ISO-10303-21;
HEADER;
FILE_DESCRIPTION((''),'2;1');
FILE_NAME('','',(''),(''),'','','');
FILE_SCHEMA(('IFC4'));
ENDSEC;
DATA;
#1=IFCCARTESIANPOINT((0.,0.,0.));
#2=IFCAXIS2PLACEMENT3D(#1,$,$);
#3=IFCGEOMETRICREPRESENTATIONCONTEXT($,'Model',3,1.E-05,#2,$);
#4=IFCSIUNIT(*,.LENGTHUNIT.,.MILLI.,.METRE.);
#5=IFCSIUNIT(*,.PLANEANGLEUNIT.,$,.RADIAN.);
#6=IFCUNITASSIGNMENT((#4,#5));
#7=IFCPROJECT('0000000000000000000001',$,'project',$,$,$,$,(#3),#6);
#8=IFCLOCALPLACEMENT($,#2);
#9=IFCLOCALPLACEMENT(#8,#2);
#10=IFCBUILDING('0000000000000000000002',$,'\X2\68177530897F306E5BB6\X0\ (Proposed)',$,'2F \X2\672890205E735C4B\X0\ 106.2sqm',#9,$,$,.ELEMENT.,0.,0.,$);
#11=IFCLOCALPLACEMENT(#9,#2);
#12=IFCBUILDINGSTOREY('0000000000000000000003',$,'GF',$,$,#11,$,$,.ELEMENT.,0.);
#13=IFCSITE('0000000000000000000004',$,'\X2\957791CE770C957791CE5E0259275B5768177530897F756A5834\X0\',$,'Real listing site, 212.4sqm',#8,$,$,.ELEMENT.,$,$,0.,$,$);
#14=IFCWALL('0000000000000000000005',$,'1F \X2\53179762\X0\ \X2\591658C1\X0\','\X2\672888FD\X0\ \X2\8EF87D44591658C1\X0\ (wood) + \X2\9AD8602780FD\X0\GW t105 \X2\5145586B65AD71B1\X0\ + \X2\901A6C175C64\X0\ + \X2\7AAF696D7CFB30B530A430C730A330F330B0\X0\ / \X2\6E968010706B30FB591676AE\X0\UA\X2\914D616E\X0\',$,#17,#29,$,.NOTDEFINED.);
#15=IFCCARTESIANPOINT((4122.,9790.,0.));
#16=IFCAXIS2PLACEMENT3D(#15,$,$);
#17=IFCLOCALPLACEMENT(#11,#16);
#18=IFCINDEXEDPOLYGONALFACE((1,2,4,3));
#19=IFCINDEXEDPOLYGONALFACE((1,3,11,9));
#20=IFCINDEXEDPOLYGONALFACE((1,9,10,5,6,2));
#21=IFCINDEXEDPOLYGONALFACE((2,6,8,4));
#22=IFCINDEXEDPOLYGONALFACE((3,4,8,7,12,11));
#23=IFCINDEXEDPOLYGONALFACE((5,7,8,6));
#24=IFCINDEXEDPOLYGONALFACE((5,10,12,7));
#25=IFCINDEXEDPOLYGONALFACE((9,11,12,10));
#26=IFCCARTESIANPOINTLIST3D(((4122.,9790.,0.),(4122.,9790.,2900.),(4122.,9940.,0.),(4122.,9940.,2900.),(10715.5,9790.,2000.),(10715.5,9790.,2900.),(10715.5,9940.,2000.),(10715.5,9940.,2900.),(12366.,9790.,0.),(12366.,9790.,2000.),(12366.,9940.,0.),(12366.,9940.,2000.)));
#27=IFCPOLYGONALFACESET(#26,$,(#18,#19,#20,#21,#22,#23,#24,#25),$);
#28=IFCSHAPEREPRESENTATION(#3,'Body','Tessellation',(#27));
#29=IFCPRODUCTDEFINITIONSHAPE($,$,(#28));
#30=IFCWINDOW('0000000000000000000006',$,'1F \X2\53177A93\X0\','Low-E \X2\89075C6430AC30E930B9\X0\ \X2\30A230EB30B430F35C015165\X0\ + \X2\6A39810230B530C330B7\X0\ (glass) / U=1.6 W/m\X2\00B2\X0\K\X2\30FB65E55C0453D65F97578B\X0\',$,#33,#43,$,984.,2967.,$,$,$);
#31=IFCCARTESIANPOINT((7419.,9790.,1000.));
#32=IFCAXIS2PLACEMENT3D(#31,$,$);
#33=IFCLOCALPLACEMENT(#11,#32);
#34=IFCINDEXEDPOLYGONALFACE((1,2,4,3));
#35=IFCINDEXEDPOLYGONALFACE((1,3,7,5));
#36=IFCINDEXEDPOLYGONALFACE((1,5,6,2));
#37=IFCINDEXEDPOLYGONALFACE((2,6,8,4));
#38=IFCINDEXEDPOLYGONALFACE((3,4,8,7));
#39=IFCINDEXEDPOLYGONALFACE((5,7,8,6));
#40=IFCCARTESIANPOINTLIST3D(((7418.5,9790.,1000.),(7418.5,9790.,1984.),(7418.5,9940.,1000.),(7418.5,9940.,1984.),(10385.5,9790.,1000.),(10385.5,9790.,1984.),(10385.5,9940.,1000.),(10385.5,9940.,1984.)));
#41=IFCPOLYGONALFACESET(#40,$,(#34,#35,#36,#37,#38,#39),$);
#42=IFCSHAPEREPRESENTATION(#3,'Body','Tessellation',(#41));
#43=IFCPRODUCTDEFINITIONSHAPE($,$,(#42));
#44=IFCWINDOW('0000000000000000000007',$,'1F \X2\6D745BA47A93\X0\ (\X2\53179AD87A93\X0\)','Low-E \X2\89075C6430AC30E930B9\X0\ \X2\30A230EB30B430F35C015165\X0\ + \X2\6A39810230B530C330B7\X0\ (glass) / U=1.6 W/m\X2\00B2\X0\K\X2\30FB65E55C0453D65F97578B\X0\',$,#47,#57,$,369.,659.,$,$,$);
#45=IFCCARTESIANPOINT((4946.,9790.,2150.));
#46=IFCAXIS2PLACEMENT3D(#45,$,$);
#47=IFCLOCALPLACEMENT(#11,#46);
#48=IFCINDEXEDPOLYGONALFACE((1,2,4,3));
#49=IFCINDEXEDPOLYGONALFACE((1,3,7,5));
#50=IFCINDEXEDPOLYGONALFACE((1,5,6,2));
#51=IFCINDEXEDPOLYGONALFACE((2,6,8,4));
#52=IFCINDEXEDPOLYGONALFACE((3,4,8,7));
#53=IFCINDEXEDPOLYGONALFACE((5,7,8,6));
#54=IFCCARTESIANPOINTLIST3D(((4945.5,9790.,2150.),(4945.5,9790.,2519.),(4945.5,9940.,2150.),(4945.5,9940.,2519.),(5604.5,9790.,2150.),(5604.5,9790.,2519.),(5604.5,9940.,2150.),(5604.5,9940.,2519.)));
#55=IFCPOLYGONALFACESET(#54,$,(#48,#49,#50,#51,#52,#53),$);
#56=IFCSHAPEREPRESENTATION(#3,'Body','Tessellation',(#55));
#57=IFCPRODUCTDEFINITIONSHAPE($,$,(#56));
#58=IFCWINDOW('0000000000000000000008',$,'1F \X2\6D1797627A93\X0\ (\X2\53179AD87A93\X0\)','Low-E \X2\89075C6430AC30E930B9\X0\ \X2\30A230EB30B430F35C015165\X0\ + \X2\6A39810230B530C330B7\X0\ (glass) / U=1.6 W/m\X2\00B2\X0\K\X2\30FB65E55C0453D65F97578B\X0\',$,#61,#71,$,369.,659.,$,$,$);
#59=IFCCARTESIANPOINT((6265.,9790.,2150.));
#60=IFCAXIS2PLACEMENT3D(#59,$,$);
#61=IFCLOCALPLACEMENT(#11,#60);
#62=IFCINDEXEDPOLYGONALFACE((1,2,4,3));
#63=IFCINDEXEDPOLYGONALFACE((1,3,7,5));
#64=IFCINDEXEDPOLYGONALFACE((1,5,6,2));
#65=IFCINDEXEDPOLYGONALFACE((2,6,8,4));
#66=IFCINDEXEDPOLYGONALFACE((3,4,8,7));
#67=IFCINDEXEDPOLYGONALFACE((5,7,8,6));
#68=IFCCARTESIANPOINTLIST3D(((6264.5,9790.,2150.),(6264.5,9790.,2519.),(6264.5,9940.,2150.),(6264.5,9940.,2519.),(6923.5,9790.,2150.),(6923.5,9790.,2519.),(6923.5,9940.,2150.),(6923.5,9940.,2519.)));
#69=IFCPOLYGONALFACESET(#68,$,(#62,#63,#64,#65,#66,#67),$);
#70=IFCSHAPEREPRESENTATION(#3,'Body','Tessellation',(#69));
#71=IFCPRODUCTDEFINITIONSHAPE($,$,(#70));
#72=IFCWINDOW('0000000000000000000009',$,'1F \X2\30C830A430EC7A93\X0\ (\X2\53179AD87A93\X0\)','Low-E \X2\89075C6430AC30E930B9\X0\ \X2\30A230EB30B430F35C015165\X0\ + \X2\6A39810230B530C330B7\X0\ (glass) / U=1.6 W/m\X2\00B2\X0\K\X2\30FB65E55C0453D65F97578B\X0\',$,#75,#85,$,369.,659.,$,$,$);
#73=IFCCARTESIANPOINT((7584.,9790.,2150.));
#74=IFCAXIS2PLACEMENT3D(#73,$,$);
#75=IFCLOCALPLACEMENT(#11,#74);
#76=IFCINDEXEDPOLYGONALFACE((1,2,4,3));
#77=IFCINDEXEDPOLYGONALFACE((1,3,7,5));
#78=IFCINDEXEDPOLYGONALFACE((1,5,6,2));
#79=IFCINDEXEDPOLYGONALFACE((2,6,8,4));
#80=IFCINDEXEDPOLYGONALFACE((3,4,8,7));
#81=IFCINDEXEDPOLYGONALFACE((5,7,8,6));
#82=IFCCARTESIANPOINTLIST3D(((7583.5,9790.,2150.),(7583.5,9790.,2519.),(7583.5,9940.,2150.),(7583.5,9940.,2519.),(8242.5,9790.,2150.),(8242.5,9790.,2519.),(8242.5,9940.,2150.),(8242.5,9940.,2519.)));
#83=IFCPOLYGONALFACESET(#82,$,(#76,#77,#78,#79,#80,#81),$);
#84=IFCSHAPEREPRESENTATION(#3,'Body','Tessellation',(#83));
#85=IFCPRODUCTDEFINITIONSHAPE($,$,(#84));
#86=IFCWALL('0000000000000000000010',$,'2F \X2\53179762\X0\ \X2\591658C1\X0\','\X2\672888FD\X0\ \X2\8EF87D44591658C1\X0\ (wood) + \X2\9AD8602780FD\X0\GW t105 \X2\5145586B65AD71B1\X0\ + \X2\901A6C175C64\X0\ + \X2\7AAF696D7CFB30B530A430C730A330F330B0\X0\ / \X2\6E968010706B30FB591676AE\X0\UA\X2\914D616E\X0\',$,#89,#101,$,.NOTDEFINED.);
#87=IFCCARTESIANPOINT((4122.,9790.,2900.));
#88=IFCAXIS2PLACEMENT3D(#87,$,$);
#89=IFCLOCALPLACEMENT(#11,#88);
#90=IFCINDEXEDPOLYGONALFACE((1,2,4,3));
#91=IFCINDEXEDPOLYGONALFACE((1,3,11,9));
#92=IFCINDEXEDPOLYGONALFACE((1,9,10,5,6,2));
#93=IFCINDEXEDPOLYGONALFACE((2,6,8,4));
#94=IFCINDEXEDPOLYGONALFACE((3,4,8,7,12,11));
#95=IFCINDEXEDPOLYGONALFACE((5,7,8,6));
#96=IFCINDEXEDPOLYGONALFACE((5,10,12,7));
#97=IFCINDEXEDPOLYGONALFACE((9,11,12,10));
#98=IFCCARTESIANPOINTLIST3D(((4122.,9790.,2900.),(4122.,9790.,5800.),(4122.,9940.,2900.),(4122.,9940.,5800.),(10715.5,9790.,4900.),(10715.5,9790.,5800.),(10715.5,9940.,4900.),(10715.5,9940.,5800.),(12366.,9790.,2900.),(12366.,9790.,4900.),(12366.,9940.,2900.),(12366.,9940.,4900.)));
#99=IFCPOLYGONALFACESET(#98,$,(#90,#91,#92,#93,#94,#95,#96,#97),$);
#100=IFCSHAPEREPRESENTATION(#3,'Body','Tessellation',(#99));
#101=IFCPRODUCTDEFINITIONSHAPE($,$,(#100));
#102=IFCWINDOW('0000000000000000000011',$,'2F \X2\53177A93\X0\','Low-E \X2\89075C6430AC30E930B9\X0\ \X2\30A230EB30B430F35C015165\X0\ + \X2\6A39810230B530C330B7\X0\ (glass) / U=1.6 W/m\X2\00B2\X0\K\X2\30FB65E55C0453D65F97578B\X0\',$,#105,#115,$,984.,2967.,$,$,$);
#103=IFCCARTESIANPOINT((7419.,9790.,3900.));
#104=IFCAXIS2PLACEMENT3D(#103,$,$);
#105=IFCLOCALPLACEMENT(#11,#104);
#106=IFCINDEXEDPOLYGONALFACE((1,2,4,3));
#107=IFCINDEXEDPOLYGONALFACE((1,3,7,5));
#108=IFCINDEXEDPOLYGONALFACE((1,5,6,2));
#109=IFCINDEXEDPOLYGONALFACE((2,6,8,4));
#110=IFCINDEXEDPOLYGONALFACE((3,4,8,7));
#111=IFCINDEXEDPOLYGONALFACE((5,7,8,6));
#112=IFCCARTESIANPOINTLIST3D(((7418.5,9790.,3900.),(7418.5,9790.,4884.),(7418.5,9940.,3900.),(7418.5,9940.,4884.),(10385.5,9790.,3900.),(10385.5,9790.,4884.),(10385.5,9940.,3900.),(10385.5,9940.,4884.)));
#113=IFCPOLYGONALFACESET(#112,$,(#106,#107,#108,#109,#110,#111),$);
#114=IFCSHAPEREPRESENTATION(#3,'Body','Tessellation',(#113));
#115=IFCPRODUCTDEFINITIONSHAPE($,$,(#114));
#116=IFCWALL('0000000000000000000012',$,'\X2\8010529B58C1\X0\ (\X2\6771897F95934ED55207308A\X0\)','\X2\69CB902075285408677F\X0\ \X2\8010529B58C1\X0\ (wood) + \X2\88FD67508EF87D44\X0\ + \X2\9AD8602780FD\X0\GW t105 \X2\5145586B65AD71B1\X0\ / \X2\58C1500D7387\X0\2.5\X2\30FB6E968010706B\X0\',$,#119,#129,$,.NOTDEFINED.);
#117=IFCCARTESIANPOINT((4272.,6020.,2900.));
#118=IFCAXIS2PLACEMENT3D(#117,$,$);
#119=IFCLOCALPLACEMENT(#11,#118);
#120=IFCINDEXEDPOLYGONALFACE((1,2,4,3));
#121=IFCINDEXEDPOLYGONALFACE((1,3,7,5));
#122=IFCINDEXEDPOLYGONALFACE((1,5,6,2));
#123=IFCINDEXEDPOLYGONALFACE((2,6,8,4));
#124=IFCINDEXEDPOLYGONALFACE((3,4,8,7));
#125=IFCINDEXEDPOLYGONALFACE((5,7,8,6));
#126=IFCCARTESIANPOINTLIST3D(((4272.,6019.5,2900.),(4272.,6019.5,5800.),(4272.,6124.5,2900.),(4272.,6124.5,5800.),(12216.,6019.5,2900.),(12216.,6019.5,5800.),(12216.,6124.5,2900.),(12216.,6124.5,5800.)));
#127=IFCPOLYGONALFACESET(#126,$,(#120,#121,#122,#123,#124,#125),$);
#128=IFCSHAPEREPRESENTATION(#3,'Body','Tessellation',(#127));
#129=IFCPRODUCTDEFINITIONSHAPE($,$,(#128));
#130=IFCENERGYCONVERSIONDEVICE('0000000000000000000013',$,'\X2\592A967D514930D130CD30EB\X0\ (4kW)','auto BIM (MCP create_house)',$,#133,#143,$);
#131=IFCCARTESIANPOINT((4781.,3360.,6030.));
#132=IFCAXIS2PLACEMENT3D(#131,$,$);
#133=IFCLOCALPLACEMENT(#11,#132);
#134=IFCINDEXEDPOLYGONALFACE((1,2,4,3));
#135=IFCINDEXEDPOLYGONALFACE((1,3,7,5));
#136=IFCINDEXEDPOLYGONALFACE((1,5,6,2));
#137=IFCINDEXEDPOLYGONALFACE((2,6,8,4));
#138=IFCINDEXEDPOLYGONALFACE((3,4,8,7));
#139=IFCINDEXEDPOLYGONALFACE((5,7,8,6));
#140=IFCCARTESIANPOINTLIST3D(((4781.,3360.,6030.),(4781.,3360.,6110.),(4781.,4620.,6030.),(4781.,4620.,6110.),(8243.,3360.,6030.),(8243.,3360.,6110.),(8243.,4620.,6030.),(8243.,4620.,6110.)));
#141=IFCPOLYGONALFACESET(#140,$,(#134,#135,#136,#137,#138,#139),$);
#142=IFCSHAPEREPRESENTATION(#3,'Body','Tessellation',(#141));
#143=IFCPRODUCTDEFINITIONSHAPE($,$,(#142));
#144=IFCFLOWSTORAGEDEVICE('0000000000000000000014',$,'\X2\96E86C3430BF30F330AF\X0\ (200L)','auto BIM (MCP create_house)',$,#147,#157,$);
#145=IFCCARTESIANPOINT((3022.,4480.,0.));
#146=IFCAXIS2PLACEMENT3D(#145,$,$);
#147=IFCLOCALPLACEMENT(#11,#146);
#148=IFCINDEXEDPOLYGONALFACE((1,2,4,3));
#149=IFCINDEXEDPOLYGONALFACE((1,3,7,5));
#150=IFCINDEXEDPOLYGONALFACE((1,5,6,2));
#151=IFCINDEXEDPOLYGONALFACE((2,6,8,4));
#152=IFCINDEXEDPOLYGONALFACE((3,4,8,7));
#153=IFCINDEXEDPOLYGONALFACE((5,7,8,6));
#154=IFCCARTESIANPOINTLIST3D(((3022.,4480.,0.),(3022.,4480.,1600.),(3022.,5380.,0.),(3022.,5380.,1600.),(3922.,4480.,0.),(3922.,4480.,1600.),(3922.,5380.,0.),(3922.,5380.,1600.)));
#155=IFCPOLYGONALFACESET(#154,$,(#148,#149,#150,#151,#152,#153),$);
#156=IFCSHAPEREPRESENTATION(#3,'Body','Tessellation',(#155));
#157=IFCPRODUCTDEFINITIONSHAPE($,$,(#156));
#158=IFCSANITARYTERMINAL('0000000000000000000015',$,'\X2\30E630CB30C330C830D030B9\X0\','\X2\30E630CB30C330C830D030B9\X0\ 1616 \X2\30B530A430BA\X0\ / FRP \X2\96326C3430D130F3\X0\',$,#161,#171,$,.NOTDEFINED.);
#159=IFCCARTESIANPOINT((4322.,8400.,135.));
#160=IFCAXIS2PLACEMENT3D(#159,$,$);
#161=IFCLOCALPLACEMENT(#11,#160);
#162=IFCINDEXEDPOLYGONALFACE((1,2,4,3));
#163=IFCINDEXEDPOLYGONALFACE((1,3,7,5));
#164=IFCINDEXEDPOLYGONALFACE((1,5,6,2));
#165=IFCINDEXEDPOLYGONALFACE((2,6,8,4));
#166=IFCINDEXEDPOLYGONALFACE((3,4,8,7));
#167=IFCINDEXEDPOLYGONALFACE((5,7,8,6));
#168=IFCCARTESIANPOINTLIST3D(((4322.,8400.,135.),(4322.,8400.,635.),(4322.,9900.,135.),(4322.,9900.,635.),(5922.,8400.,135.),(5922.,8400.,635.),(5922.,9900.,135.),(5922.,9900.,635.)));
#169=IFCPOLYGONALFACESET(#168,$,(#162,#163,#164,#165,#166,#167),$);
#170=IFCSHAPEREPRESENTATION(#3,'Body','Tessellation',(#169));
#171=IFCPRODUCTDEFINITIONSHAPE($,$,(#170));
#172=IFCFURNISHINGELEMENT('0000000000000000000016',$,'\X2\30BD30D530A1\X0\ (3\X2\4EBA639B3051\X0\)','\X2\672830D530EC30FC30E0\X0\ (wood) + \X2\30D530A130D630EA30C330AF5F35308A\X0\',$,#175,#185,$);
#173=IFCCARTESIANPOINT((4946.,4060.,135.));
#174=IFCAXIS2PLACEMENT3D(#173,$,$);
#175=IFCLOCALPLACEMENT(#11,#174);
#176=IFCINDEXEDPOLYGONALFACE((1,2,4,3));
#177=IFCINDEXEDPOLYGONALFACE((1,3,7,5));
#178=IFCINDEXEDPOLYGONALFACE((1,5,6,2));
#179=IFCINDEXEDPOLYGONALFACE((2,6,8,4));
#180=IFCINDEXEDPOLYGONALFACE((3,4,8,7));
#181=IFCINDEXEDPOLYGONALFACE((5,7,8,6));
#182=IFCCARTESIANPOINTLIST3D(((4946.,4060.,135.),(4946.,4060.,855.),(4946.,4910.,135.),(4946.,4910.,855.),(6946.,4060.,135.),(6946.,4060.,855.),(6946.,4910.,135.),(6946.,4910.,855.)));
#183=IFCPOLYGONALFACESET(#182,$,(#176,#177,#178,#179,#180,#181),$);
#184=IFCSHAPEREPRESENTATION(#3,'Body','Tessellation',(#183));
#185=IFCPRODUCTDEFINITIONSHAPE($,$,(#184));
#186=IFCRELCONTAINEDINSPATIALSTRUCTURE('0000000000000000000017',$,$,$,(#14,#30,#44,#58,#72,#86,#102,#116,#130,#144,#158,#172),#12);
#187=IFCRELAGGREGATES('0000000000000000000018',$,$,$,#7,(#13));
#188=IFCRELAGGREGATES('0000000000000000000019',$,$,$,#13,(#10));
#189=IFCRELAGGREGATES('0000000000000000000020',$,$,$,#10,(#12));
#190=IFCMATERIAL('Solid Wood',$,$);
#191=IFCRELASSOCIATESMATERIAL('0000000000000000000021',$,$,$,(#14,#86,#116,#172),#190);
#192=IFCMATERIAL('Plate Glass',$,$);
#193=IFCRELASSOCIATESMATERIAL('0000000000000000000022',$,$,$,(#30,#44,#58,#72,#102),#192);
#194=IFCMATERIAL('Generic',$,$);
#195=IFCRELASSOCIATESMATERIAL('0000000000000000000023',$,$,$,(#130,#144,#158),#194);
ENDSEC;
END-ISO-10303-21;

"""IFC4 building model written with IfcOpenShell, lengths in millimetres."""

from ifc_helpers import new_model, si_unit, frame, frame_2d, origin, place, context, project, spatial, rectangle, extrude, material, element, fill, save


model = new_model("IFC4")

# Units and contexts
model_context = context("Model", 3, precision=1e-05, world=origin())
ifc_project = project(units=[si_unit("LENGTHUNIT", "METRE", prefix="MILLI"), si_unit("PLANEANGLEUNIT", "RADIAN")], contexts=[model_context])

# Site, building, storey
site_placement = place(None, origin())
site = spatial("IfcSite", under=ifc_project, at=site_placement, Name="長野県長野市大字栗田西番場", ObjectType="Real listing site, 212.4sqm", CompositionType="ELEMENT", RefElevation=0.0)
building_placement = place(site_placement, origin())
building = spatial("IfcBuilding", under=site, at=building_placement, Name="栗田西の家 (Proposed)", ObjectType="2F 木造平屋 106.2sqm", CompositionType="ELEMENT", ElevationOfRefHeight=0.0, ElevationOfTerrain=0.0)
storey_placement = place(building_placement, origin())
storey = spatial("IfcBuildingStorey", under=building, at=storey_placement, Name="GF", CompositionType="ELEMENT", Elevation=0.0)

# Wall, openings, windows
ifc_material_1 = material(Name="Solid Wood")
wall_1_placement = place(storey_placement, frame((4122.0, 9790.0, 0.0)))
wall_1 = element("IfcWall", 1, at=wall_1_placement, inside=storey, material=ifc_material_1, Name="1F 北面 外壁", Description="木製 軸組外壁 (wood) + 高性能GW t105 充填断熱 + 通気層 + 窯業系サイディング / 準耐火・外皮UA配慮", PredefinedType="NOTDEFINED", context=model_context, shape_type="SweptSolid", body=[
    extrude(rectangle(XDim=8244.0, YDim=150.0, at=frame_2d((4122.0, 75.0))), frame((4122.0, 9790.0, 0.0)), (0.0, 0.0, 1.0), 2900.0),
])
opening_1_placement = place(storey_placement, frame((7419.0, 9790.0, 1000.0)))
opening_1 = element("IfcOpeningElement", 2, at=opening_1_placement, cuts=wall_1, PredefinedType="NOTDEFINED", context=model_context, shape_type="SweptSolid", body=[
    extrude(rectangle(XDim=2967.0, YDim=150.0, at=frame_2d((1483.0, 75.0))), frame((7419.0, 9790.0, 1000.0)), (0.0, 0.0, 1.0), 984.0),
])
opening_2_placement = place(storey_placement, frame((4946.0, 9790.0, 2150.0)))
opening_2 = element("IfcOpeningElement", 3, at=opening_2_placement, cuts=wall_1, PredefinedType="NOTDEFINED", context=model_context, shape_type="SweptSolid", body=[
    extrude(rectangle(XDim=659.0, YDim=150.0, at=frame_2d((329.0, 75.0))), frame((4946.0, 9790.0, 2150.0)), (0.0, 0.0, 1.0), 369.0),
])
opening_3_placement = place(storey_placement, frame((6265.0, 9790.0, 2150.0)))
opening_3 = element("IfcOpeningElement", 4, at=opening_3_placement, cuts=wall_1, PredefinedType="NOTDEFINED", context=model_context, shape_type="SweptSolid", body=[
    extrude(rectangle(XDim=659.0, YDim=150.0, at=frame_2d((329.0, 75.0))), frame((6265.0, 9790.0, 2150.0)), (0.0, 0.0, 1.0), 369.0),
])
opening_4_placement = place(storey_placement, frame((7584.0, 9790.0, 2150.0)))
opening_4 = element("IfcOpeningElement", 5, at=opening_4_placement, cuts=wall_1, PredefinedType="NOTDEFINED", context=model_context, shape_type="SweptSolid", body=[
    extrude(rectangle(XDim=659.0, YDim=150.0, at=frame_2d((329.0, 75.0))), frame((7584.0, 9790.0, 2150.0)), (0.0, 0.0, 1.0), 369.0),
])
ifc_material_2 = material(Name="Plate Glass")
window_1_placement = place(storey_placement, frame((7419.0, 9790.0, 1000.0)))
window_1 = element("IfcWindow", 6, at=window_1_placement, inside=storey, material=ifc_material_2, Name="1F 北窓", Description="Low-E 複層ガラス アルゴン封入 + 樹脂サッシ (glass) / U=1.6 W/m²K・日射取得型", OverallHeight=984.0, OverallWidth=2967.0, context=model_context, shape_type="SweptSolid", body=[
    extrude(rectangle(XDim=2967.0, YDim=150.0, at=frame_2d((1483.0, 75.0))), frame((7419.0, 9790.0, 1000.0)), (0.0, 0.0, 1.0), 984.0),
])
fill(opening_1, window_1)
window_2_placement = place(storey_placement, frame((4946.0, 9790.0, 2150.0)))
window_2 = element("IfcWindow", 7, at=window_2_placement, inside=storey, material=ifc_material_2, Name="1F 浴室窓 (北高窓)", Description="Low-E 複層ガラス アルゴン封入 + 樹脂サッシ (glass) / U=1.6 W/m²K・日射取得型", OverallHeight=369.0, OverallWidth=659.0, context=model_context, shape_type="SweptSolid", body=[
    extrude(rectangle(XDim=659.0, YDim=150.0, at=frame_2d((329.0, 75.0))), frame((4946.0, 9790.0, 2150.0)), (0.0, 0.0, 1.0), 369.0),
])
fill(opening_2, window_2)
window_3_placement = place(storey_placement, frame((6265.0, 9790.0, 2150.0)))
window_3 = element("IfcWindow", 8, at=window_3_placement, inside=storey, material=ifc_material_2, Name="1F 洗面窓 (北高窓)", Description="Low-E 複層ガラス アルゴン封入 + 樹脂サッシ (glass) / U=1.6 W/m²K・日射取得型", OverallHeight=369.0, OverallWidth=659.0, context=model_context, shape_type="SweptSolid", body=[
    extrude(rectangle(XDim=659.0, YDim=150.0, at=frame_2d((329.0, 75.0))), frame((6265.0, 9790.0, 2150.0)), (0.0, 0.0, 1.0), 369.0),
])
fill(opening_3, window_3)
window_4_placement = place(storey_placement, frame((7584.0, 9790.0, 2150.0)))
window_4 = element("IfcWindow", 9, at=window_4_placement, inside=storey, material=ifc_material_2, Name="1F トイレ窓 (北高窓)", Description="Low-E 複層ガラス アルゴン封入 + 樹脂サッシ (glass) / U=1.6 W/m²K・日射取得型", OverallHeight=369.0, OverallWidth=659.0, context=model_context, shape_type="SweptSolid", body=[
    extrude(rectangle(XDim=659.0, YDim=150.0, at=frame_2d((329.0, 75.0))), frame((7584.0, 9790.0, 2150.0)), (0.0, 0.0, 1.0), 369.0),
])
fill(opening_4, window_4)

# Wall, opening, window
wall_2_placement = place(storey_placement, frame((4122.0, 9790.0, 2900.0)))
wall_2 = element("IfcWall", 10, at=wall_2_placement, inside=storey, material=ifc_material_1, Name="2F 北面 外壁", Description="木製 軸組外壁 (wood) + 高性能GW t105 充填断熱 + 通気層 + 窯業系サイディング / 準耐火・外皮UA配慮", PredefinedType="NOTDEFINED", context=model_context, shape_type="SweptSolid", body=[
    extrude(rectangle(XDim=8244.0, YDim=150.0, at=frame_2d((4122.0, 75.0))), frame((4122.0, 9790.0, 2900.0)), (0.0, 0.0, 1.0), 2900.0),
])
opening_5_placement = place(storey_placement, frame((7419.0, 9790.0, 3900.0)))
opening_5 = element("IfcOpeningElement", 11, at=opening_5_placement, cuts=wall_2, PredefinedType="NOTDEFINED", context=model_context, shape_type="SweptSolid", body=[
    extrude(rectangle(XDim=2967.0, YDim=150.0, at=frame_2d((1483.0, 75.0))), frame((7419.0, 9790.0, 3900.0)), (0.0, 0.0, 1.0), 984.0),
])
window_5_placement = place(storey_placement, frame((7419.0, 9790.0, 3900.0)))
window_5 = element("IfcWindow", 12, at=window_5_placement, inside=storey, material=ifc_material_2, Name="2F 北窓", Description="Low-E 複層ガラス アルゴン封入 + 樹脂サッシ (glass) / U=1.6 W/m²K・日射取得型", OverallHeight=984.0, OverallWidth=2967.0, context=model_context, shape_type="SweptSolid", body=[
    extrude(rectangle(XDim=2967.0, YDim=150.0, at=frame_2d((1483.0, 75.0))), frame((7419.0, 9790.0, 3900.0)), (0.0, 0.0, 1.0), 984.0),
])
fill(opening_5, window_5)

# Wall
wall_3_placement = place(storey_placement, frame((4272.0, 6020.0, 2900.0)))
element("IfcWall", 13, at=wall_3_placement, inside=storey, material=ifc_material_1, Name="耐力壁 (東西間仕切り)", Description="構造用合板 耐力壁 (wood) + 製材軸組 + 高性能GW t105 充填断熱 / 壁倍率2.5・準耐火", PredefinedType="NOTDEFINED", context=model_context, shape_type="SweptSolid", body=[
    extrude(rectangle(XDim=7944.0, YDim=105.0, at=frame_2d((3972.0, 52.0))), frame((4272.0, 6020.0, 2900.0)), (0.0, 0.0, 1.0), 2900.0),
])

# Energy conversion device
ifc_material_3 = material(Name="Generic")
energy_conversion_device_placement = place(storey_placement, frame((4781.0, 3360.0, 6030.0)))
element("IfcEnergyConversionDevice", 14, at=energy_conversion_device_placement, inside=storey, material=ifc_material_3, Name="太陽光パネル (4kW)", Description="auto BIM (MCP create_house)", context=model_context, shape_type="SweptSolid", body=[
    extrude(rectangle(XDim=3462.0, YDim=1260.0, at=frame_2d((1731.0, 630.0))), frame((4781.0, 3360.0, 6030.0)), (0.0, 0.0, 1.0), 80.0),
])

# Flow storage device
flow_storage_device_placement = place(storey_placement, frame((3022.0, 4480.0, 0.0)))
element("IfcFlowStorageDevice", 15, at=flow_storage_device_placement, inside=storey, material=ifc_material_3, Name="雨水タンク (200L)", Description="auto BIM (MCP create_house)", context=model_context, shape_type="SweptSolid", body=[
    extrude(rectangle(XDim=900.0, YDim=900.0, at=frame_2d((450.0, 450.0))), frame((3022.0, 4480.0, 0.0)), (0.0, 0.0, 1.0), 1600.0),
])

# Sanitary terminal
sanitary_terminal_placement = place(storey_placement, frame((4322.0, 8400.0, 135.0)))
element("IfcSanitaryTerminal", 16, at=sanitary_terminal_placement, inside=storey, material=ifc_material_3, Name="ユニットバス", Description="ユニットバス 1616 サイズ / FRP 防水パン", PredefinedType="NOTDEFINED", context=model_context, shape_type="SweptSolid", body=[
    extrude(rectangle(XDim=1600.0, YDim=1500.0, at=frame_2d((800.0, 750.0))), frame((4322.0, 8400.0, 135.0)), (0.0, 0.0, 1.0), 500.0),
])

# Furnishing element
furnishing_1_placement = place(storey_placement, frame((4946.0, 4060.0, 135.0)))
element("IfcFurnishingElement", 17, at=furnishing_1_placement, inside=storey, material=ifc_material_1, Name="ソファ (3人掛け)", Description="木フレーム (wood) + ファブリック張り", context=model_context, shape_type="SweptSolid", body=[
    extrude(rectangle(XDim=2000.0, YDim=850.0, at=frame_2d((1000.0, 425.0))), frame((4946.0, 4060.0, 135.0)), (0.0, 0.0, 1.0), 720.0),
])

save(model, "model.ifc")
